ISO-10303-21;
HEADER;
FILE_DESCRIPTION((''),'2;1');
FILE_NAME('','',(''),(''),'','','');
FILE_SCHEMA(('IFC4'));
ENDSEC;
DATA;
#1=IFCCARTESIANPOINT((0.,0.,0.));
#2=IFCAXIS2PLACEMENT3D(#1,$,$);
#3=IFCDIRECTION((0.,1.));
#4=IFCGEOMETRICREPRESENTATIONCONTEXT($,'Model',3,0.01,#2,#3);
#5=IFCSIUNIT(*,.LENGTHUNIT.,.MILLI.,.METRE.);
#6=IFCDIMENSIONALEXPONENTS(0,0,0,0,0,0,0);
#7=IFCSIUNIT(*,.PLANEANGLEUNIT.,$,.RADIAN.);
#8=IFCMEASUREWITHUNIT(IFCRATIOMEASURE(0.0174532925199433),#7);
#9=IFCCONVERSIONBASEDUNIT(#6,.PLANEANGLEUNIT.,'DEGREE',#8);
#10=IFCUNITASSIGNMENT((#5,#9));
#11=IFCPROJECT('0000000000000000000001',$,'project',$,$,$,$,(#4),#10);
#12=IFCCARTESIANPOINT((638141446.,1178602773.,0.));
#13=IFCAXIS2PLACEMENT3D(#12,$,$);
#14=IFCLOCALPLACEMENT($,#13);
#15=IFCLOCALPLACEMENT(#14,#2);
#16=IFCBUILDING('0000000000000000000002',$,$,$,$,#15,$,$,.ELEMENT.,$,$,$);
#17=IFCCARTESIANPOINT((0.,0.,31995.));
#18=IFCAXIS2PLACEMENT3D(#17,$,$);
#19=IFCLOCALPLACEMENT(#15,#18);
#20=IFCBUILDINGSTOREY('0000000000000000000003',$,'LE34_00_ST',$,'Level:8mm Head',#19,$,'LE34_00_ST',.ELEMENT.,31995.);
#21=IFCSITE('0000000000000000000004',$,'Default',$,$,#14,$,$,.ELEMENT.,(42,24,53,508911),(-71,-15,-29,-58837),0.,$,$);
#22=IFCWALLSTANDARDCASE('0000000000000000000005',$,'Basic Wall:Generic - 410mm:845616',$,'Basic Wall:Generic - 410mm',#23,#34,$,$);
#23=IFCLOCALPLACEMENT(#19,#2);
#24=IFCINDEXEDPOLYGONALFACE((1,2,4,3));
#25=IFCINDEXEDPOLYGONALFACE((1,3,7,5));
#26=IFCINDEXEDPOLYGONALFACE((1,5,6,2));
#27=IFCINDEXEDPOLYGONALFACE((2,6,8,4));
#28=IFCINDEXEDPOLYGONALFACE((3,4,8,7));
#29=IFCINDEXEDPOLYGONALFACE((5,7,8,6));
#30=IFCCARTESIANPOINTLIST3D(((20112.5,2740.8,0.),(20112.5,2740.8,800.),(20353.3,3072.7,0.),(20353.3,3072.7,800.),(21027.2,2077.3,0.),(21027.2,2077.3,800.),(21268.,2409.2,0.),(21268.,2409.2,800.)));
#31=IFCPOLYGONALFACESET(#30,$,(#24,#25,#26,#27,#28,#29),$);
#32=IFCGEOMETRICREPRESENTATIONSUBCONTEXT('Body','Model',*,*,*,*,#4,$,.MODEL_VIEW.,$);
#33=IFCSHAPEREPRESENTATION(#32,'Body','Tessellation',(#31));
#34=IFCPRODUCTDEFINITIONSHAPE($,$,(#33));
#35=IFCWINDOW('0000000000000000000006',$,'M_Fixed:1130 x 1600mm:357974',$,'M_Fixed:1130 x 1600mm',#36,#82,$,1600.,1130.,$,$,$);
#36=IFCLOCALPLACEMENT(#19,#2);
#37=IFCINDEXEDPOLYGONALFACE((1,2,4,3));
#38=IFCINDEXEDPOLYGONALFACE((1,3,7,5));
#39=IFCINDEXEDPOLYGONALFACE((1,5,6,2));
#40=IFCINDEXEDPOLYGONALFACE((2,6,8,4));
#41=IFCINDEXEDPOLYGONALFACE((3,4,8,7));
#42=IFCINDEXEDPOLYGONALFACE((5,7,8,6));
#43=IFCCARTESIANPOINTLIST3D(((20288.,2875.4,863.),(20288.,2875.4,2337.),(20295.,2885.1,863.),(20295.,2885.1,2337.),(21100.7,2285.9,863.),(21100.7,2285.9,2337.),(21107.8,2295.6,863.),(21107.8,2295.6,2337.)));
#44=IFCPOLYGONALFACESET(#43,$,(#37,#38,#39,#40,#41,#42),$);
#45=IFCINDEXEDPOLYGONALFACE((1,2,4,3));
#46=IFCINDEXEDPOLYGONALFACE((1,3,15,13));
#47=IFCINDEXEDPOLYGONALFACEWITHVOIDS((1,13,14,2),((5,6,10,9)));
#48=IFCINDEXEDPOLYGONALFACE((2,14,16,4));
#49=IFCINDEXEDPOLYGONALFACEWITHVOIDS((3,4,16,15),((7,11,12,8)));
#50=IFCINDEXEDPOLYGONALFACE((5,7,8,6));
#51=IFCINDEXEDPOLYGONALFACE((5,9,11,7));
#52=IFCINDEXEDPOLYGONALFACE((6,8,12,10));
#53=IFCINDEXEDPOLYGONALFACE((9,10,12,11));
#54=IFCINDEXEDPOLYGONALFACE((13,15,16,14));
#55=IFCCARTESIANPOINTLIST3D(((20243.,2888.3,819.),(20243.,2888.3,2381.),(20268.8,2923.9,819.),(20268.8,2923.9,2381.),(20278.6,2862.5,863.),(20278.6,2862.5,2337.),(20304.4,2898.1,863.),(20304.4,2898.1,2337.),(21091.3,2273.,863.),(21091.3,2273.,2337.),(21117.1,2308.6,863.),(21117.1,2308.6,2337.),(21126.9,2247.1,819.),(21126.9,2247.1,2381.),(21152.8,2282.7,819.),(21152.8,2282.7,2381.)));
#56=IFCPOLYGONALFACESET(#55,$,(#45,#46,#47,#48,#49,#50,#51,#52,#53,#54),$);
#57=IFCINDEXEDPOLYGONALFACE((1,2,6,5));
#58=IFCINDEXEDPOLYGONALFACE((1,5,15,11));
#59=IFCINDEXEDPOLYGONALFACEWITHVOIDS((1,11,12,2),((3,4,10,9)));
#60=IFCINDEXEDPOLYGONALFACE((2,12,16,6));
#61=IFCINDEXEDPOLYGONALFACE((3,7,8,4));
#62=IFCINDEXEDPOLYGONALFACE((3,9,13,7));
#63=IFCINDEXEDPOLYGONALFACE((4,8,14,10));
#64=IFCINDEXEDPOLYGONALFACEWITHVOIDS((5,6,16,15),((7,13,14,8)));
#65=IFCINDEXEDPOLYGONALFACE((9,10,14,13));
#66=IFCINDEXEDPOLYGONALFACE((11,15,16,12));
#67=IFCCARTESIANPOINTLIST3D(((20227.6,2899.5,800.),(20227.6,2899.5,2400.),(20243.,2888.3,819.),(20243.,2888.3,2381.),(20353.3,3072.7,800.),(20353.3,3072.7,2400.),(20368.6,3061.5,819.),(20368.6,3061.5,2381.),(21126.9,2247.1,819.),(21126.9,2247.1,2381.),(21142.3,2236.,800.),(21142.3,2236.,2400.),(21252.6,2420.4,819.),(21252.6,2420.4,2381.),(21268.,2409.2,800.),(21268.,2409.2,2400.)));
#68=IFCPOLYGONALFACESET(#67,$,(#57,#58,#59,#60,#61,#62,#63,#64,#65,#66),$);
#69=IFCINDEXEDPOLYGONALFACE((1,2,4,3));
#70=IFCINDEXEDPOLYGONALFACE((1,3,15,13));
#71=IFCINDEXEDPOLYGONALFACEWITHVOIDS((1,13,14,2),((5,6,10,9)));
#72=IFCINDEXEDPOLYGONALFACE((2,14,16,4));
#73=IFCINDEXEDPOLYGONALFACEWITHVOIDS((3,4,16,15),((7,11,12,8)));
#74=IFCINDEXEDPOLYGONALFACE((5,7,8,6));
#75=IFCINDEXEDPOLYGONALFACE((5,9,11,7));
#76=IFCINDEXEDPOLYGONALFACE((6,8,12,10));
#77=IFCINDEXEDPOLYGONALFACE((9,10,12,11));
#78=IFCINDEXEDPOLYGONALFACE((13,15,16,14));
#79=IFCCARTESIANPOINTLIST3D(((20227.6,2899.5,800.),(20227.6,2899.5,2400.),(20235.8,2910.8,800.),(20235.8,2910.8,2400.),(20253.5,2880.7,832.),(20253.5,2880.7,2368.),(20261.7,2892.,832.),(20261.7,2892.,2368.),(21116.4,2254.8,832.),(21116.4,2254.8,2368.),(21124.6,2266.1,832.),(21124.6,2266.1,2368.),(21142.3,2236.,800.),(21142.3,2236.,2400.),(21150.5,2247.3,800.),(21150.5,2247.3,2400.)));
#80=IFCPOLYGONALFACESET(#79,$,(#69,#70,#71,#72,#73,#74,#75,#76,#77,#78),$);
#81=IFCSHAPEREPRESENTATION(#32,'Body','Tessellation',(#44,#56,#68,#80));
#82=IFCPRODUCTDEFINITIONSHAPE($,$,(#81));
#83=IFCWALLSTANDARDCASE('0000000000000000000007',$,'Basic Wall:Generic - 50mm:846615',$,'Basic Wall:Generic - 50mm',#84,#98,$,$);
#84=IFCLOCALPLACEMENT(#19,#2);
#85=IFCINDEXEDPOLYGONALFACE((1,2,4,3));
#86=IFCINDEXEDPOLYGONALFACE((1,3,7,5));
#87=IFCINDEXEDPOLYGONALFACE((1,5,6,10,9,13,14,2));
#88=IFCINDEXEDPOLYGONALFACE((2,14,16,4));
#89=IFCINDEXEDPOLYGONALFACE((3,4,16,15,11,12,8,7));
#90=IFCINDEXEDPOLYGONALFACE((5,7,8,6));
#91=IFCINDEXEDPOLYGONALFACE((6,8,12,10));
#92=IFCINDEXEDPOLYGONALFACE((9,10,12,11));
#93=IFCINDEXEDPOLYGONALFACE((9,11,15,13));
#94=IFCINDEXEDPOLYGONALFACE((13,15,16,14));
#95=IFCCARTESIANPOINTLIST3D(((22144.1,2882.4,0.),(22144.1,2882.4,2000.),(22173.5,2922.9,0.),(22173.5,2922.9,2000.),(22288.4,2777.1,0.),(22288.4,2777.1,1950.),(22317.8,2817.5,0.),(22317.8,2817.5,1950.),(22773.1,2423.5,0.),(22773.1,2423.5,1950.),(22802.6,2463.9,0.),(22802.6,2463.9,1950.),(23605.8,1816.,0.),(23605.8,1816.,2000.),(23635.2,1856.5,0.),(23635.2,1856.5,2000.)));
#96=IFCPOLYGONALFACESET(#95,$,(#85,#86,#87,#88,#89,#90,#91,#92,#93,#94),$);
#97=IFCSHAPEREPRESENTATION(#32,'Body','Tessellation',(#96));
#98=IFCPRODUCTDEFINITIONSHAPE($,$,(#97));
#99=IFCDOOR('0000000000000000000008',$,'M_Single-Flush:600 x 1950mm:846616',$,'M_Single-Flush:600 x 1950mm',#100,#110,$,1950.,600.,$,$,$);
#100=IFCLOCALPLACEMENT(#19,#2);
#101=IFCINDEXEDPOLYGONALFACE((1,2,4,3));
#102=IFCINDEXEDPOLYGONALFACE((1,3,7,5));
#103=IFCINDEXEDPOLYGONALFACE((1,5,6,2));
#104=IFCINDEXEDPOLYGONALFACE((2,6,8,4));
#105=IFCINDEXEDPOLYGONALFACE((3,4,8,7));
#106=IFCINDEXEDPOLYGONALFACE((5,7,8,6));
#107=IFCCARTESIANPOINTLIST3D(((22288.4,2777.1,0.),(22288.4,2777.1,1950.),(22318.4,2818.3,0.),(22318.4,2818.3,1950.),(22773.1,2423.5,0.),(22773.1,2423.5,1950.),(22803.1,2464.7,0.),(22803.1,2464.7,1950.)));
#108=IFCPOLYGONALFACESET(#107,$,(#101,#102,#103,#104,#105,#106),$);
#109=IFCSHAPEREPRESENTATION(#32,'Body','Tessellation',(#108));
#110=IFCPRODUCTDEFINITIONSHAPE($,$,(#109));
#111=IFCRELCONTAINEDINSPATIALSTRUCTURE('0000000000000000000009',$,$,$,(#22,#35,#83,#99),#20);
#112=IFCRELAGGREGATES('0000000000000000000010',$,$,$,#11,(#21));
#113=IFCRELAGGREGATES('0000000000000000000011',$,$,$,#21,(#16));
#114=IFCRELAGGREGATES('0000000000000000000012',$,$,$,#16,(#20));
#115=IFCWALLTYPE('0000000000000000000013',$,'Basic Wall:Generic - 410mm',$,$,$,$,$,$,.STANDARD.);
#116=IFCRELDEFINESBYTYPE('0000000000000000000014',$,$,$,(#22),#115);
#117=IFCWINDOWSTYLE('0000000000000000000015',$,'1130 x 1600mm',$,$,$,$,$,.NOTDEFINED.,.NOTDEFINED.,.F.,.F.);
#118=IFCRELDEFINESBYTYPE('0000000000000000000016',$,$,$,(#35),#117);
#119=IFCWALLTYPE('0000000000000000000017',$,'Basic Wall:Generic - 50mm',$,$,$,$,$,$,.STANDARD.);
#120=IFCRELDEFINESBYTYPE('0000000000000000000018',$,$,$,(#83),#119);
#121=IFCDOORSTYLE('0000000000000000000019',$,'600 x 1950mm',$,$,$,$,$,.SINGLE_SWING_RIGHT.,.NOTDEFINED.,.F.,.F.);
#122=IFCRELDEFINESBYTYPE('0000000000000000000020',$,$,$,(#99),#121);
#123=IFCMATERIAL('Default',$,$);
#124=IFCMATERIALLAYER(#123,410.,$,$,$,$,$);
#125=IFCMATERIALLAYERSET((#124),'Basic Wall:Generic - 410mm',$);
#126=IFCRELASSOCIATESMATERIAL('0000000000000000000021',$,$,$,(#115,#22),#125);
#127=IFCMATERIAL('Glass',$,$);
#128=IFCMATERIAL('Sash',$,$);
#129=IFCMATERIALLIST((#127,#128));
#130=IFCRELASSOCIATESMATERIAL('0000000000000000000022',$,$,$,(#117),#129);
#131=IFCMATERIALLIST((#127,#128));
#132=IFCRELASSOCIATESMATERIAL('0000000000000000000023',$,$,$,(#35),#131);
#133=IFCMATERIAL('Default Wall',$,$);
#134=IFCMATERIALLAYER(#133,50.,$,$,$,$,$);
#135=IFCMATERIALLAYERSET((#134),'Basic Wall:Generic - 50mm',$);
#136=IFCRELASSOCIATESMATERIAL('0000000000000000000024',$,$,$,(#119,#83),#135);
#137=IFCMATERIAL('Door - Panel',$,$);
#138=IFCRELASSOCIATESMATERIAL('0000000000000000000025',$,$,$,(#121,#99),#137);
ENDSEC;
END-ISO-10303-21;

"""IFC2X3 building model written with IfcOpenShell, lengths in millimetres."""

from ifc_helpers import new_model, entity, si_unit, converted_unit, direction, frame, frame_2d, origin, origin_2d_with_axis, place, context, subcontext, project, spatial, polyline, rectangle, outline, extrude, source, transform, mapped, material, material_list, layer, layer_set, layer_usage, type_object, type_shapes, element, fill, save


model = new_model("IFC2X3")

# Units and contexts
model_context = context("Model", 3, precision=0.01, world=origin(), true_north=direction((0.0, 1.0)))
body_context = subcontext(model_context, "Body", "Model", "MODEL_VIEW")
ifc_project = project(units=[si_unit("LENGTHUNIT", "METRE", prefix="MILLI"), converted_unit("PLANEANGLEUNIT", "DEGREE", entity("IfcRatioMeasure", 0.0174532925199433), si_unit("PLANEANGLEUNIT", "RADIAN"), dimensions=[0, 0, 0, 0, 0, 0, 0])], contexts=[model_context])

# Site, building, storey
site_placement = place(None, frame((638141446.0, 1178602773.0, 0.0)))
site = spatial("IfcSite", under=ifc_project, at=site_placement, Name="Default", CompositionType="ELEMENT", RefLatitude=(42, 24, 53, 508911), RefLongitude=(-71, -15, -29, -58837), RefElevation=0.0)
building_placement = place(site_placement, origin())
building = spatial("IfcBuilding", under=site, at=building_placement, CompositionType="ELEMENT")
storey_placement = place(building_placement, frame((0.0, 0.0, 31995.0)))
storey = spatial("IfcBuildingStorey", under=building, at=storey_placement, Name="LE34_00_ST", ObjectType="Level:8mm Head", LongName="LE34_00_ST", CompositionType="ELEMENT", Elevation=31995.0)

# Shared definitions
ifc_material_1 = material(Name="Default")

# Wall, opening, window
ifc_layer_1 = layer(ifc_material_1, 410.0)
ifc_layer_set_1 = layer_set([ifc_layer_1], Name="Basic Wall:Generic - 410mm")
ifc_layer_usage_1 = layer_usage(ifc_layer_set_1, "AXIS2", "NEGATIVE", 205.0)
wall_type_1 = type_object("IfcWallType", Name="Basic Wall:Generic - 410mm", PredefinedType="STANDARD", material=ifc_layer_set_1)
wall_1_placement = place(storey_placement, frame((21147.6, 2243.3, 0.0), z_axis=(0.0, 0.0, 1.0), x_axis=(-0.809468, 0.587164, 0.0)))
wall_1 = element("IfcWallStandardCase", 1, at=wall_1_placement, inside=storey, type_object=wall_type_1, material=ifc_layer_usage_1, Name="Basic Wall:Generic - 410mm:845616", ObjectType="Basic Wall:Generic - 410mm", context=body_context, shape_type="SweptSolid", body=[
    extrude(rectangle(XDim=1130.0, YDim=410.0, at=frame_2d((565.0, 0.0), x_axis=(-1.0, 0.0))), origin(), (0.0, 0.0, 1.0), 800.0),
])
opening_1_placement = place(wall_1_placement, frame((1130.0, 205.0, 800.0)))
opening_1 = element("IfcOpeningElement", 2, at=opening_1_placement, cuts=wall_1, ObjectType="Opening", context=body_context, shape_type="SweptSolid", body=[
    extrude(rectangle(XDim=1600.0, YDim=1130.0, at=frame_2d((800.0, 565.0), x_axis=(1.0, 0.0))), frame((0.0, 0.0, 0.0), z_axis=(0.0, -1.0, 0.0), x_axis=(0.0, 0.0, 1.0)), (0.0, 0.0, 1.0), 410.0),
])
ifc_material_2 = material(Name="Glass")
ifc_material_3 = material(Name="Sash")
ifc_material_list_1 = material_list([ifc_material_2, ifc_material_3])
ifc_material_list_2 = material_list([ifc_material_2, ifc_material_3])
window_style = type_object("IfcWindowStyle", Name="1130 x 1600mm", ConstructionType="NOTDEFINED", OperationType="NOTDEFINED", ParameterTakesPrecedence=False, Sizeable=False, material=ifc_material_list_2)
shared_shape_1 = source(origin(), body_context, "Body", "SweptSolid", [
    extrude(rectangle(XDim=12.0, YDim=1004.0, at=origin_2d_with_axis()), frame((565.0, 218.0, 63.0), z_axis=(0.0, 0.0, 1.0), x_axis=(0.0, -1.0, 0.0)), (0.0, 0.0, 1.0), 1474.0),
    extrude(outline(polyline([(-546.0, -781.0), (546.0, -781.0), (546.0, 781.0), (-546.0, 781.0), (-546.0, -781.0)]), holes=[polyline([(-502.0, -737.0), (-502.0, 737.0), (502.0, 737.0), (502.0, -737.0), (-502.0, -737.0)])]), frame((565.0, 196.0, 800.0), z_axis=(0.0, 1.0, 0.0), x_axis=(1.0, 0.0, 0.0)), (0.0, 0.0, 1.0), 44.0),
    extrude(outline(polyline([(-565.0, -800.0), (565.0, -800.0), (565.0, 800.0), (-565.0, 800.0), (-565.0, -800.0)]), holes=[polyline([(-546.0, -781.0), (-546.0, 781.0), (546.0, 781.0), (546.0, -781.0), (-546.0, -781.0)])]), frame((565.0, 196.0, 800.0), z_axis=(0.0, 1.0, 0.0), x_axis=(1.0, 0.0, 0.0)), (0.0, 0.0, 1.0), 214.0),
    extrude(outline(polyline([(-565.0, -800.0), (565.0, -800.0), (565.0, 800.0), (-565.0, 800.0), (-565.0, -800.0)]), holes=[polyline([(-533.0, -768.0), (-533.0, 768.0), (533.0, 768.0), (533.0, -768.0), (-533.0, -768.0)])]), frame((565.0, 196.0, 800.0), z_axis=(0.0, 1.0, 0.0), x_axis=(1.0, 0.0, 0.0)), (0.0, 0.0, 1.0), 14.0),
])
type_shapes(window_style, [shared_shape_1])
window_placement = place(opening_1_placement, frame((0.0, 0.0, 0.0), z_axis=(0.0, 0.0, 1.0), x_axis=(-1.0, 0.0, 0.0)))
window = element("IfcWindow", 3, at=window_placement, inside=storey, type_object=window_style, material=ifc_material_list_1, Name="M_Fixed:1130 x 1600mm:357974", ObjectType="M_Fixed:1130 x 1600mm", OverallHeight=1600.0, OverallWidth=1130.0, context=body_context, shape_type="MappedRepresentation", body=[
    mapped(shared_shape_1, transform((0.0, 0.0, 0.0), scale=1.0)),
])
fill(opening_1, window)

# Wall, opening, door
ifc_material_4 = material(Name="Default Wall")
ifc_layer_2 = layer(ifc_material_4, 50.0)
ifc_layer_set_2 = layer_set([ifc_layer_2], Name="Basic Wall:Generic - 50mm")
ifc_layer_usage_2 = layer_usage(ifc_layer_set_2, "AXIS2", "NEGATIVE", 25.0)
wall_type_2 = type_object("IfcWallType", Name="Basic Wall:Generic - 50mm", PredefinedType="STANDARD", material=ifc_layer_set_2)
wall_2_placement = place(storey_placement, frame((23620.6, 1836.2, 0.0), z_axis=(0.0, 0.0, 1.0), x_axis=(-0.807862, 0.589372, 0.0)))
wall_2 = element("IfcWallStandardCase", 4, at=wall_2_placement, inside=storey, type_object=wall_type_2, material=ifc_layer_usage_2, Name="Basic Wall:Generic - 50mm:846615", ObjectType="Basic Wall:Generic - 50mm", context=body_context, shape_type="SweptSolid", body=[
    extrude(outline(polyline([(0.1, -25.0), (1809.5, -25.0), (1809.4, 25.0), (0.0, 25.0), (0.1, -25.0)])), origin(), (0.0, 0.0, 1.0), 2000.0),
])
opening_2_placement = place(wall_2_placement, frame((1030.8, -25.0, 0.0)))
opening_2 = element("IfcOpeningElement", 5, at=opening_2_placement, cuts=wall_2, ObjectType="Opening", context=body_context, shape_type="SweptSolid", body=[
    extrude(rectangle(XDim=600.0, YDim=1950.0, at=frame_2d((975.0, 300.0), x_axis=(0.0, 1.0))), frame((0.0, 0.0, 0.0), z_axis=(0.0, 1.0, 0.0), x_axis=(0.0, 0.0, 1.0)), (0.0, 0.0, 1.0), 50.0),
])
ifc_material_5 = material(Name="Door - Panel")
door_style = type_object("IfcDoorStyle", Name="600 x 1950mm", ConstructionType="NOTDEFINED", OperationType="SINGLE_SWING_RIGHT", ParameterTakesPrecedence=False, Sizeable=False, material=ifc_material_5)
shared_shape_2 = source(origin(), body_context, "Body", "SweptSolid", [
    extrude(rectangle(XDim=51.0, YDim=600.0, at=origin_2d_with_axis()), frame((300.0, 24.5, 0.0), z_axis=(0.0, 0.0, 1.0), x_axis=(0.0, 1.0, 0.0)), (0.0, 0.0, 1.0), 1950.0),
])
type_shapes(door_style, [shared_shape_2])
door_placement = place(opening_2_placement, origin())
door = element("IfcDoor", 6, at=door_placement, inside=storey, type_object=door_style, material=ifc_material_5, Name="M_Single-Flush:600 x 1950mm:846616", ObjectType="M_Single-Flush:600 x 1950mm", OverallHeight=1950.0, OverallWidth=600.0, context=body_context, shape_type="MappedRepresentation", body=[
    mapped(shared_shape_2, transform((0.0, 0.0, 0.0), scale=1.0)),
])
fill(opening_2, door)

save(model, "model.ifc")
